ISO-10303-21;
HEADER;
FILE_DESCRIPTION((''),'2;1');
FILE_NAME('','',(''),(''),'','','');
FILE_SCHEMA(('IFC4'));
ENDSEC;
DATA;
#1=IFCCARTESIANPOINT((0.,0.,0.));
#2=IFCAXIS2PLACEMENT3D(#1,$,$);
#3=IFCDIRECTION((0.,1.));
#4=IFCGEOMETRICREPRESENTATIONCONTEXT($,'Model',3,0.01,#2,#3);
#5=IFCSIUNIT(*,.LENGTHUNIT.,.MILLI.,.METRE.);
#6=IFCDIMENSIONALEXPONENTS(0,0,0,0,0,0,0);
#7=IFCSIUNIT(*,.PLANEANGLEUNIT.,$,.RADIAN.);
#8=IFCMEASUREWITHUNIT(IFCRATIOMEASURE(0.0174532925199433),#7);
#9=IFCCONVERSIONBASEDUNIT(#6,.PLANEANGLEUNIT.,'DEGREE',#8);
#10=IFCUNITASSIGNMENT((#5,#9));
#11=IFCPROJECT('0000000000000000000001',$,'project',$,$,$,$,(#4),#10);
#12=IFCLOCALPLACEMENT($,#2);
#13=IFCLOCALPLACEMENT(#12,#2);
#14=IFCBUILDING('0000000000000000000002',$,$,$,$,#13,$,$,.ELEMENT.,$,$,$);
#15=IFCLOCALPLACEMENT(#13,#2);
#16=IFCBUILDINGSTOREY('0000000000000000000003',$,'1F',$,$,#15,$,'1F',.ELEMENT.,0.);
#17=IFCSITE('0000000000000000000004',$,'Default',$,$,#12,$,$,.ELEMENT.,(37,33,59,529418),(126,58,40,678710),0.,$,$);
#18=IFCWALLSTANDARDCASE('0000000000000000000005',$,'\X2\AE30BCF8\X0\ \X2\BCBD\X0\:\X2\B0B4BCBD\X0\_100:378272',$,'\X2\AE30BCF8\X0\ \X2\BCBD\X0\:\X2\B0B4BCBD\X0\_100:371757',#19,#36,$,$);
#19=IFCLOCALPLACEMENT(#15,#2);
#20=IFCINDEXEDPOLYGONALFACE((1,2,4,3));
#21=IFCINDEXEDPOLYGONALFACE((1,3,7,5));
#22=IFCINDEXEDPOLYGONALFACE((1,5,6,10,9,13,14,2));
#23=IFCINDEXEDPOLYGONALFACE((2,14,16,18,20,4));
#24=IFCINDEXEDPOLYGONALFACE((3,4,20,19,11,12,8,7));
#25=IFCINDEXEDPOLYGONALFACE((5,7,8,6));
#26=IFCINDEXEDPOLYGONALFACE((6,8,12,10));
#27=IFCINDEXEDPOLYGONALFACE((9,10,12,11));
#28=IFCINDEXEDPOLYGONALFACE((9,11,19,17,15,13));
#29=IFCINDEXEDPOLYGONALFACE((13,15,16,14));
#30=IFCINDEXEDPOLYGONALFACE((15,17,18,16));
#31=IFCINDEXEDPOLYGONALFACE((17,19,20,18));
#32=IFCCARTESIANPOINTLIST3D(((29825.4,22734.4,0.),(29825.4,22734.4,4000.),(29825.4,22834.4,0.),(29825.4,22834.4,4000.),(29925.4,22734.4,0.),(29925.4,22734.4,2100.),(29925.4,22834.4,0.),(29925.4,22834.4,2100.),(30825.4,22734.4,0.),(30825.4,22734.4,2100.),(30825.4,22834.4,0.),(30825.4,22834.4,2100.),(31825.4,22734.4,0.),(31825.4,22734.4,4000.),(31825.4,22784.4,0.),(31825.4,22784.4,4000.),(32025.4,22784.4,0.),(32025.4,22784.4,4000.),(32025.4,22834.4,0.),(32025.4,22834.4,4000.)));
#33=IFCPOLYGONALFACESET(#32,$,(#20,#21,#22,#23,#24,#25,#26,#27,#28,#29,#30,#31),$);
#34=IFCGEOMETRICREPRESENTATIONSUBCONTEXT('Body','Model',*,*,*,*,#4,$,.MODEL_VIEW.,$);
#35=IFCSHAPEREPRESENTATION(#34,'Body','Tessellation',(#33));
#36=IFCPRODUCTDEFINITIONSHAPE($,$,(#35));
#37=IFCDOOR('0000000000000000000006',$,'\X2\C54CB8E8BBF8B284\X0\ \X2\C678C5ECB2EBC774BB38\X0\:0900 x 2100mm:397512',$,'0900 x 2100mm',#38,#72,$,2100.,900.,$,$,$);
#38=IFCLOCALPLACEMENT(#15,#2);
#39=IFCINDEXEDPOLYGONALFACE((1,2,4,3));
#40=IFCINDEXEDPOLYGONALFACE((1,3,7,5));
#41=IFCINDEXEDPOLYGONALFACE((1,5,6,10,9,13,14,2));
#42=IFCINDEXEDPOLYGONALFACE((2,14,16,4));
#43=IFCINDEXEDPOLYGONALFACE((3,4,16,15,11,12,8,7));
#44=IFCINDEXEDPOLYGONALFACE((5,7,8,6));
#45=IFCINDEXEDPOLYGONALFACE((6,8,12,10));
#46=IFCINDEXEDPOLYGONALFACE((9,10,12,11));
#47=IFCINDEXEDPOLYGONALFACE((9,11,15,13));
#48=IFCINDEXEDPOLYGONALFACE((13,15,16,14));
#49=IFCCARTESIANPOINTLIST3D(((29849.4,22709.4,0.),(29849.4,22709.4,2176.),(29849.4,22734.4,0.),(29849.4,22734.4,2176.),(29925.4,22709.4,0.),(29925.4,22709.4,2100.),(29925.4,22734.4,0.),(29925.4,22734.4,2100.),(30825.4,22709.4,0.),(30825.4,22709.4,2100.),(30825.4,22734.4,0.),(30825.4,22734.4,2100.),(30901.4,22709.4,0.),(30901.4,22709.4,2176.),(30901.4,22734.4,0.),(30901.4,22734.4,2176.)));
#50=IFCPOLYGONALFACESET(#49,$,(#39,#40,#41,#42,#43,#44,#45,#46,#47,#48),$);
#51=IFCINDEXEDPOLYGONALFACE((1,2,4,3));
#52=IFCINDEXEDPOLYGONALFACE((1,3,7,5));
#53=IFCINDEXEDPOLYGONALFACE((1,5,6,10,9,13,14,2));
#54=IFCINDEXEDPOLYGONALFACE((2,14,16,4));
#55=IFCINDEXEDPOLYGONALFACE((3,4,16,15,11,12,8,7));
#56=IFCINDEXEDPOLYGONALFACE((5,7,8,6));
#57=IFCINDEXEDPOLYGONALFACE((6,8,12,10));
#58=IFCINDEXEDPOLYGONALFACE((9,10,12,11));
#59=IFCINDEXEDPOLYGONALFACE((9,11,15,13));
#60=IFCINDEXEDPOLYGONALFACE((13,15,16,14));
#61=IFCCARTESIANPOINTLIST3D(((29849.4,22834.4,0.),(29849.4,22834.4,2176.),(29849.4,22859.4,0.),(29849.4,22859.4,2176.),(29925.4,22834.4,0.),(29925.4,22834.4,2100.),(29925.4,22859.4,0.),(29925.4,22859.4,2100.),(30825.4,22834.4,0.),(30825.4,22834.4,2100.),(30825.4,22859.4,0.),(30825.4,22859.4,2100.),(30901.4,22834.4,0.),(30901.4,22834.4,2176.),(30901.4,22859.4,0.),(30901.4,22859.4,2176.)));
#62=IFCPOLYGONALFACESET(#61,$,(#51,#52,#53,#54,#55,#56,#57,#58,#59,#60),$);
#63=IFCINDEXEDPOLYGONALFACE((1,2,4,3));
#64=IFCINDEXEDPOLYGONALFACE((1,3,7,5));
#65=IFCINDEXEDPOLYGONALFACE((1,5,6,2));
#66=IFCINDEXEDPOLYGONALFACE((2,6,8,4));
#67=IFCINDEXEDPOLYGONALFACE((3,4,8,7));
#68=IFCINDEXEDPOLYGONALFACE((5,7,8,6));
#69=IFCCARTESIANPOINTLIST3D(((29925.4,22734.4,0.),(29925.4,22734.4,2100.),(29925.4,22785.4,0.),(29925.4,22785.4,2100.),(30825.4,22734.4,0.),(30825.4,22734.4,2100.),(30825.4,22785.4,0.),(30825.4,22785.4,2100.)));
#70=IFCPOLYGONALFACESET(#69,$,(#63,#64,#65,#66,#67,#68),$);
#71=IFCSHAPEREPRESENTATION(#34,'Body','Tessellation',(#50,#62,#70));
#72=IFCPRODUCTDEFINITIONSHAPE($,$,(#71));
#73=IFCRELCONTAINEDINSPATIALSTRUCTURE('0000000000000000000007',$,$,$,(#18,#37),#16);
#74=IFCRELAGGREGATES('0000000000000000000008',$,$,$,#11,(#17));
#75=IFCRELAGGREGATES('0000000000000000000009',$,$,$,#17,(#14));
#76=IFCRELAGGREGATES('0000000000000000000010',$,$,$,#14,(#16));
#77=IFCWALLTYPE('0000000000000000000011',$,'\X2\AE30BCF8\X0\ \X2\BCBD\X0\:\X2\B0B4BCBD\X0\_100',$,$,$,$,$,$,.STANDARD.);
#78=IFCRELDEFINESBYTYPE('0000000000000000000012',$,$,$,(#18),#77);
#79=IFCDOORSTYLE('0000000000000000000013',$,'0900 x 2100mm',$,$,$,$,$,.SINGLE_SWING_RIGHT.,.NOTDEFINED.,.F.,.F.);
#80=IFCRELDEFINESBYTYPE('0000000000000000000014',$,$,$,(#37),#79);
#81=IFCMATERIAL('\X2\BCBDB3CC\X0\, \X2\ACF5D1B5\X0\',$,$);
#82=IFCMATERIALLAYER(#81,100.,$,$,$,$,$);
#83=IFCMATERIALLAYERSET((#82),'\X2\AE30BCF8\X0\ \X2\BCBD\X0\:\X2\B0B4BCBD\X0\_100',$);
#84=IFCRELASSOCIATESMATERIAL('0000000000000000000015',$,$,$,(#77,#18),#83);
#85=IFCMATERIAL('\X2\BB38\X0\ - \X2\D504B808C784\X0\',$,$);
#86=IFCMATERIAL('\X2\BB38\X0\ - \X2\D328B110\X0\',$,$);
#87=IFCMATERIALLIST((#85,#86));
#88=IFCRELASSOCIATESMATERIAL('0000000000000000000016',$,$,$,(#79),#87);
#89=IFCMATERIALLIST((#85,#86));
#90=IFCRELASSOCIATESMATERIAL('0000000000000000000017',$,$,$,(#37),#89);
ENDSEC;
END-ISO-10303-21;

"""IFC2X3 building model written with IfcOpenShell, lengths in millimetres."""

from ifc_helpers import new_model, entity, si_unit, converted_unit, direction, frame, frame_2d, origin, origin_2d_with_axis, place, context, subcontext, project, spatial, polyline, rectangle, outline, extrude, source, transform, mapped, material, material_list, layer, layer_set, layer_usage, type_object, type_shapes, element, fill, save


model = new_model("IFC2X3")

# Units and contexts
model_context = context("Model", 3, precision=0.01, world=origin(), true_north=direction((0.0, 1.0)))
body_context = subcontext(model_context, "Body", "Model", "MODEL_VIEW")
ifc_project = project(units=[si_unit("LENGTHUNIT", "METRE", prefix="MILLI"), converted_unit("PLANEANGLEUNIT", "DEGREE", entity("IfcRatioMeasure", 0.0174532925199433), si_unit("PLANEANGLEUNIT", "RADIAN"), dimensions=[0, 0, 0, 0, 0, 0, 0])], contexts=[model_context])

# Site, building, storey
site_placement = place(None, origin())
site = spatial("IfcSite", under=ifc_project, at=site_placement, Name="Default", CompositionType="ELEMENT", RefLatitude=(37, 33, 59, 529418), RefLongitude=(126, 58, 40, 678710), RefElevation=0.0)
building_placement = place(site_placement, origin())
building = spatial("IfcBuilding", under=site, at=building_placement, CompositionType="ELEMENT")
storey_placement = place(building_placement, origin())
storey = spatial("IfcBuildingStorey", under=building, at=storey_placement, Name="1F", LongName="1F", CompositionType="ELEMENT", Elevation=0.0)

# Shared definitions
ifc_material_1 = material(Name="벽돌, 공통")
ifc_material_2 = material(Name="문 - 프레임")
ifc_material_3 = material(Name="문 - 패널")

# Shared definitions
ifc_layer_1 = layer(ifc_material_1, 100.0)
ifc_layer_set_1 = layer_set([ifc_layer_1], Name="기본 벽:내벽_100")
wall_type_1 = type_object("IfcWallType", Name="기본 벽:내벽_100", PredefinedType="STANDARD", material=ifc_layer_set_1)

# Wall, opening, door
ifc_layer_usage_1 = layer_usage(ifc_layer_set_1, "AXIS2", "NEGATIVE", 50.0)
wall_1_placement = place(storey_placement, frame((32025.4, 22784.4, 0.0), z_axis=(0.0, 0.0, 1.0), x_axis=(-1.0, 0.0, 0.0)))
wall_1 = element("IfcWallStandardCase", 1, at=wall_1_placement, inside=storey, type_object=wall_type_1, material=ifc_layer_usage_1, Name="기본 벽:내벽_100:378272", ObjectType="기본 벽:내벽_100:371757", context=body_context, shape_type="SweptSolid", body=[
    extrude(outline(polyline([(0.0, -50.0), (2200.0, -50.0), (2200.0, 50.0), (200.0, 50.0), (200.0, 0.0), (0.0, 0.0), (0.0, -50.0)])), origin(), (0.0, 0.0, 1.0), 4000.0),
])
opening_1_placement = place(wall_1_placement, frame((1200.0, -50.0, 0.0)))
opening_1 = element("IfcOpeningElement", 2, at=opening_1_placement, cuts=wall_1, ObjectType="Opening", context=body_context, shape_type="SweptSolid", body=[
    extrude(rectangle(XDim=900.0, YDim=2100.0, at=frame_2d((1050.0, 450.0), x_axis=(0.0, 1.0))), frame((0.0, 0.0, 0.0), z_axis=(0.0, 1.0, 0.0), x_axis=(0.0, 0.0, 1.0)), (0.0, 0.0, 1.0), 100.0),
])
ifc_material_list_1 = material_list([ifc_material_2, ifc_material_3])
ifc_material_list_2 = material_list([ifc_material_2, ifc_material_3])
door_style_1 = type_object("IfcDoorStyle", Name="0900 x 2100mm", ConstructionType="NOTDEFINED", OperationType="SINGLE_SWING_RIGHT", ParameterTakesPrecedence=False, Sizeable=False, material=ifc_material_list_2)
shared_shape_1 = source(origin(), body_context, "Body", "SweptSolid", [
    extrude(outline(polyline([(-526.0, -1107.0), (526.0, -1107.0), (526.0, 1069.0), (450.0, 1069.0), (450.0, -1031.0), (-450.0, -1031.0), (-450.0, 1069.0), (-526.0, 1069.0), (-526.0, -1107.0)])), frame((450.0, 100.0, 1069.0), z_axis=(0.0, 1.0, 0.0), x_axis=(1.0, 0.0, 0.0)), (0.0, 0.0, 1.0), 25.0),
    extrude(outline(polyline([(-1107.0, -526.0), (1069.0, -526.0), (1069.0, -450.0), (-1031.0, -450.0), (-1031.0, 450.0), (1069.0, 450.0), (1069.0, 526.0), (-1107.0, 526.0), (-1107.0, -526.0)])), frame((450.0, -25.0, 1069.0), z_axis=(0.0, 1.0, 0.0), x_axis=(0.0, 0.0, -1.0)), (0.0, 0.0, 1.0), 25.0),
    extrude(rectangle(XDim=51.0, YDim=900.0, at=origin_2d_with_axis()), frame((450.0, 74.5, 0.0), z_axis=(0.0, 0.0, 1.0), x_axis=(0.0, 1.0, 0.0)), (0.0, 0.0, 1.0), 2100.0),
])
type_shapes(door_style_1, [shared_shape_1])
door_1_placement = place(opening_1_placement, origin())
door_1 = element("IfcDoor", 3, at=door_1_placement, inside=storey, type_object=door_style_1, material=ifc_material_list_1, Name="알루미늄 외여닫이문:0900 x 2100mm:397512", ObjectType="0900 x 2100mm", OverallHeight=2100.0, OverallWidth=900.0, context=body_context, shape_type="MappedRepresentation", body=[
    mapped(shared_shape_1, transform((0.0, 0.0, 0.0), scale=1.0)),
])
fill(opening_1, door_1)

save(model, "model.ifc")
